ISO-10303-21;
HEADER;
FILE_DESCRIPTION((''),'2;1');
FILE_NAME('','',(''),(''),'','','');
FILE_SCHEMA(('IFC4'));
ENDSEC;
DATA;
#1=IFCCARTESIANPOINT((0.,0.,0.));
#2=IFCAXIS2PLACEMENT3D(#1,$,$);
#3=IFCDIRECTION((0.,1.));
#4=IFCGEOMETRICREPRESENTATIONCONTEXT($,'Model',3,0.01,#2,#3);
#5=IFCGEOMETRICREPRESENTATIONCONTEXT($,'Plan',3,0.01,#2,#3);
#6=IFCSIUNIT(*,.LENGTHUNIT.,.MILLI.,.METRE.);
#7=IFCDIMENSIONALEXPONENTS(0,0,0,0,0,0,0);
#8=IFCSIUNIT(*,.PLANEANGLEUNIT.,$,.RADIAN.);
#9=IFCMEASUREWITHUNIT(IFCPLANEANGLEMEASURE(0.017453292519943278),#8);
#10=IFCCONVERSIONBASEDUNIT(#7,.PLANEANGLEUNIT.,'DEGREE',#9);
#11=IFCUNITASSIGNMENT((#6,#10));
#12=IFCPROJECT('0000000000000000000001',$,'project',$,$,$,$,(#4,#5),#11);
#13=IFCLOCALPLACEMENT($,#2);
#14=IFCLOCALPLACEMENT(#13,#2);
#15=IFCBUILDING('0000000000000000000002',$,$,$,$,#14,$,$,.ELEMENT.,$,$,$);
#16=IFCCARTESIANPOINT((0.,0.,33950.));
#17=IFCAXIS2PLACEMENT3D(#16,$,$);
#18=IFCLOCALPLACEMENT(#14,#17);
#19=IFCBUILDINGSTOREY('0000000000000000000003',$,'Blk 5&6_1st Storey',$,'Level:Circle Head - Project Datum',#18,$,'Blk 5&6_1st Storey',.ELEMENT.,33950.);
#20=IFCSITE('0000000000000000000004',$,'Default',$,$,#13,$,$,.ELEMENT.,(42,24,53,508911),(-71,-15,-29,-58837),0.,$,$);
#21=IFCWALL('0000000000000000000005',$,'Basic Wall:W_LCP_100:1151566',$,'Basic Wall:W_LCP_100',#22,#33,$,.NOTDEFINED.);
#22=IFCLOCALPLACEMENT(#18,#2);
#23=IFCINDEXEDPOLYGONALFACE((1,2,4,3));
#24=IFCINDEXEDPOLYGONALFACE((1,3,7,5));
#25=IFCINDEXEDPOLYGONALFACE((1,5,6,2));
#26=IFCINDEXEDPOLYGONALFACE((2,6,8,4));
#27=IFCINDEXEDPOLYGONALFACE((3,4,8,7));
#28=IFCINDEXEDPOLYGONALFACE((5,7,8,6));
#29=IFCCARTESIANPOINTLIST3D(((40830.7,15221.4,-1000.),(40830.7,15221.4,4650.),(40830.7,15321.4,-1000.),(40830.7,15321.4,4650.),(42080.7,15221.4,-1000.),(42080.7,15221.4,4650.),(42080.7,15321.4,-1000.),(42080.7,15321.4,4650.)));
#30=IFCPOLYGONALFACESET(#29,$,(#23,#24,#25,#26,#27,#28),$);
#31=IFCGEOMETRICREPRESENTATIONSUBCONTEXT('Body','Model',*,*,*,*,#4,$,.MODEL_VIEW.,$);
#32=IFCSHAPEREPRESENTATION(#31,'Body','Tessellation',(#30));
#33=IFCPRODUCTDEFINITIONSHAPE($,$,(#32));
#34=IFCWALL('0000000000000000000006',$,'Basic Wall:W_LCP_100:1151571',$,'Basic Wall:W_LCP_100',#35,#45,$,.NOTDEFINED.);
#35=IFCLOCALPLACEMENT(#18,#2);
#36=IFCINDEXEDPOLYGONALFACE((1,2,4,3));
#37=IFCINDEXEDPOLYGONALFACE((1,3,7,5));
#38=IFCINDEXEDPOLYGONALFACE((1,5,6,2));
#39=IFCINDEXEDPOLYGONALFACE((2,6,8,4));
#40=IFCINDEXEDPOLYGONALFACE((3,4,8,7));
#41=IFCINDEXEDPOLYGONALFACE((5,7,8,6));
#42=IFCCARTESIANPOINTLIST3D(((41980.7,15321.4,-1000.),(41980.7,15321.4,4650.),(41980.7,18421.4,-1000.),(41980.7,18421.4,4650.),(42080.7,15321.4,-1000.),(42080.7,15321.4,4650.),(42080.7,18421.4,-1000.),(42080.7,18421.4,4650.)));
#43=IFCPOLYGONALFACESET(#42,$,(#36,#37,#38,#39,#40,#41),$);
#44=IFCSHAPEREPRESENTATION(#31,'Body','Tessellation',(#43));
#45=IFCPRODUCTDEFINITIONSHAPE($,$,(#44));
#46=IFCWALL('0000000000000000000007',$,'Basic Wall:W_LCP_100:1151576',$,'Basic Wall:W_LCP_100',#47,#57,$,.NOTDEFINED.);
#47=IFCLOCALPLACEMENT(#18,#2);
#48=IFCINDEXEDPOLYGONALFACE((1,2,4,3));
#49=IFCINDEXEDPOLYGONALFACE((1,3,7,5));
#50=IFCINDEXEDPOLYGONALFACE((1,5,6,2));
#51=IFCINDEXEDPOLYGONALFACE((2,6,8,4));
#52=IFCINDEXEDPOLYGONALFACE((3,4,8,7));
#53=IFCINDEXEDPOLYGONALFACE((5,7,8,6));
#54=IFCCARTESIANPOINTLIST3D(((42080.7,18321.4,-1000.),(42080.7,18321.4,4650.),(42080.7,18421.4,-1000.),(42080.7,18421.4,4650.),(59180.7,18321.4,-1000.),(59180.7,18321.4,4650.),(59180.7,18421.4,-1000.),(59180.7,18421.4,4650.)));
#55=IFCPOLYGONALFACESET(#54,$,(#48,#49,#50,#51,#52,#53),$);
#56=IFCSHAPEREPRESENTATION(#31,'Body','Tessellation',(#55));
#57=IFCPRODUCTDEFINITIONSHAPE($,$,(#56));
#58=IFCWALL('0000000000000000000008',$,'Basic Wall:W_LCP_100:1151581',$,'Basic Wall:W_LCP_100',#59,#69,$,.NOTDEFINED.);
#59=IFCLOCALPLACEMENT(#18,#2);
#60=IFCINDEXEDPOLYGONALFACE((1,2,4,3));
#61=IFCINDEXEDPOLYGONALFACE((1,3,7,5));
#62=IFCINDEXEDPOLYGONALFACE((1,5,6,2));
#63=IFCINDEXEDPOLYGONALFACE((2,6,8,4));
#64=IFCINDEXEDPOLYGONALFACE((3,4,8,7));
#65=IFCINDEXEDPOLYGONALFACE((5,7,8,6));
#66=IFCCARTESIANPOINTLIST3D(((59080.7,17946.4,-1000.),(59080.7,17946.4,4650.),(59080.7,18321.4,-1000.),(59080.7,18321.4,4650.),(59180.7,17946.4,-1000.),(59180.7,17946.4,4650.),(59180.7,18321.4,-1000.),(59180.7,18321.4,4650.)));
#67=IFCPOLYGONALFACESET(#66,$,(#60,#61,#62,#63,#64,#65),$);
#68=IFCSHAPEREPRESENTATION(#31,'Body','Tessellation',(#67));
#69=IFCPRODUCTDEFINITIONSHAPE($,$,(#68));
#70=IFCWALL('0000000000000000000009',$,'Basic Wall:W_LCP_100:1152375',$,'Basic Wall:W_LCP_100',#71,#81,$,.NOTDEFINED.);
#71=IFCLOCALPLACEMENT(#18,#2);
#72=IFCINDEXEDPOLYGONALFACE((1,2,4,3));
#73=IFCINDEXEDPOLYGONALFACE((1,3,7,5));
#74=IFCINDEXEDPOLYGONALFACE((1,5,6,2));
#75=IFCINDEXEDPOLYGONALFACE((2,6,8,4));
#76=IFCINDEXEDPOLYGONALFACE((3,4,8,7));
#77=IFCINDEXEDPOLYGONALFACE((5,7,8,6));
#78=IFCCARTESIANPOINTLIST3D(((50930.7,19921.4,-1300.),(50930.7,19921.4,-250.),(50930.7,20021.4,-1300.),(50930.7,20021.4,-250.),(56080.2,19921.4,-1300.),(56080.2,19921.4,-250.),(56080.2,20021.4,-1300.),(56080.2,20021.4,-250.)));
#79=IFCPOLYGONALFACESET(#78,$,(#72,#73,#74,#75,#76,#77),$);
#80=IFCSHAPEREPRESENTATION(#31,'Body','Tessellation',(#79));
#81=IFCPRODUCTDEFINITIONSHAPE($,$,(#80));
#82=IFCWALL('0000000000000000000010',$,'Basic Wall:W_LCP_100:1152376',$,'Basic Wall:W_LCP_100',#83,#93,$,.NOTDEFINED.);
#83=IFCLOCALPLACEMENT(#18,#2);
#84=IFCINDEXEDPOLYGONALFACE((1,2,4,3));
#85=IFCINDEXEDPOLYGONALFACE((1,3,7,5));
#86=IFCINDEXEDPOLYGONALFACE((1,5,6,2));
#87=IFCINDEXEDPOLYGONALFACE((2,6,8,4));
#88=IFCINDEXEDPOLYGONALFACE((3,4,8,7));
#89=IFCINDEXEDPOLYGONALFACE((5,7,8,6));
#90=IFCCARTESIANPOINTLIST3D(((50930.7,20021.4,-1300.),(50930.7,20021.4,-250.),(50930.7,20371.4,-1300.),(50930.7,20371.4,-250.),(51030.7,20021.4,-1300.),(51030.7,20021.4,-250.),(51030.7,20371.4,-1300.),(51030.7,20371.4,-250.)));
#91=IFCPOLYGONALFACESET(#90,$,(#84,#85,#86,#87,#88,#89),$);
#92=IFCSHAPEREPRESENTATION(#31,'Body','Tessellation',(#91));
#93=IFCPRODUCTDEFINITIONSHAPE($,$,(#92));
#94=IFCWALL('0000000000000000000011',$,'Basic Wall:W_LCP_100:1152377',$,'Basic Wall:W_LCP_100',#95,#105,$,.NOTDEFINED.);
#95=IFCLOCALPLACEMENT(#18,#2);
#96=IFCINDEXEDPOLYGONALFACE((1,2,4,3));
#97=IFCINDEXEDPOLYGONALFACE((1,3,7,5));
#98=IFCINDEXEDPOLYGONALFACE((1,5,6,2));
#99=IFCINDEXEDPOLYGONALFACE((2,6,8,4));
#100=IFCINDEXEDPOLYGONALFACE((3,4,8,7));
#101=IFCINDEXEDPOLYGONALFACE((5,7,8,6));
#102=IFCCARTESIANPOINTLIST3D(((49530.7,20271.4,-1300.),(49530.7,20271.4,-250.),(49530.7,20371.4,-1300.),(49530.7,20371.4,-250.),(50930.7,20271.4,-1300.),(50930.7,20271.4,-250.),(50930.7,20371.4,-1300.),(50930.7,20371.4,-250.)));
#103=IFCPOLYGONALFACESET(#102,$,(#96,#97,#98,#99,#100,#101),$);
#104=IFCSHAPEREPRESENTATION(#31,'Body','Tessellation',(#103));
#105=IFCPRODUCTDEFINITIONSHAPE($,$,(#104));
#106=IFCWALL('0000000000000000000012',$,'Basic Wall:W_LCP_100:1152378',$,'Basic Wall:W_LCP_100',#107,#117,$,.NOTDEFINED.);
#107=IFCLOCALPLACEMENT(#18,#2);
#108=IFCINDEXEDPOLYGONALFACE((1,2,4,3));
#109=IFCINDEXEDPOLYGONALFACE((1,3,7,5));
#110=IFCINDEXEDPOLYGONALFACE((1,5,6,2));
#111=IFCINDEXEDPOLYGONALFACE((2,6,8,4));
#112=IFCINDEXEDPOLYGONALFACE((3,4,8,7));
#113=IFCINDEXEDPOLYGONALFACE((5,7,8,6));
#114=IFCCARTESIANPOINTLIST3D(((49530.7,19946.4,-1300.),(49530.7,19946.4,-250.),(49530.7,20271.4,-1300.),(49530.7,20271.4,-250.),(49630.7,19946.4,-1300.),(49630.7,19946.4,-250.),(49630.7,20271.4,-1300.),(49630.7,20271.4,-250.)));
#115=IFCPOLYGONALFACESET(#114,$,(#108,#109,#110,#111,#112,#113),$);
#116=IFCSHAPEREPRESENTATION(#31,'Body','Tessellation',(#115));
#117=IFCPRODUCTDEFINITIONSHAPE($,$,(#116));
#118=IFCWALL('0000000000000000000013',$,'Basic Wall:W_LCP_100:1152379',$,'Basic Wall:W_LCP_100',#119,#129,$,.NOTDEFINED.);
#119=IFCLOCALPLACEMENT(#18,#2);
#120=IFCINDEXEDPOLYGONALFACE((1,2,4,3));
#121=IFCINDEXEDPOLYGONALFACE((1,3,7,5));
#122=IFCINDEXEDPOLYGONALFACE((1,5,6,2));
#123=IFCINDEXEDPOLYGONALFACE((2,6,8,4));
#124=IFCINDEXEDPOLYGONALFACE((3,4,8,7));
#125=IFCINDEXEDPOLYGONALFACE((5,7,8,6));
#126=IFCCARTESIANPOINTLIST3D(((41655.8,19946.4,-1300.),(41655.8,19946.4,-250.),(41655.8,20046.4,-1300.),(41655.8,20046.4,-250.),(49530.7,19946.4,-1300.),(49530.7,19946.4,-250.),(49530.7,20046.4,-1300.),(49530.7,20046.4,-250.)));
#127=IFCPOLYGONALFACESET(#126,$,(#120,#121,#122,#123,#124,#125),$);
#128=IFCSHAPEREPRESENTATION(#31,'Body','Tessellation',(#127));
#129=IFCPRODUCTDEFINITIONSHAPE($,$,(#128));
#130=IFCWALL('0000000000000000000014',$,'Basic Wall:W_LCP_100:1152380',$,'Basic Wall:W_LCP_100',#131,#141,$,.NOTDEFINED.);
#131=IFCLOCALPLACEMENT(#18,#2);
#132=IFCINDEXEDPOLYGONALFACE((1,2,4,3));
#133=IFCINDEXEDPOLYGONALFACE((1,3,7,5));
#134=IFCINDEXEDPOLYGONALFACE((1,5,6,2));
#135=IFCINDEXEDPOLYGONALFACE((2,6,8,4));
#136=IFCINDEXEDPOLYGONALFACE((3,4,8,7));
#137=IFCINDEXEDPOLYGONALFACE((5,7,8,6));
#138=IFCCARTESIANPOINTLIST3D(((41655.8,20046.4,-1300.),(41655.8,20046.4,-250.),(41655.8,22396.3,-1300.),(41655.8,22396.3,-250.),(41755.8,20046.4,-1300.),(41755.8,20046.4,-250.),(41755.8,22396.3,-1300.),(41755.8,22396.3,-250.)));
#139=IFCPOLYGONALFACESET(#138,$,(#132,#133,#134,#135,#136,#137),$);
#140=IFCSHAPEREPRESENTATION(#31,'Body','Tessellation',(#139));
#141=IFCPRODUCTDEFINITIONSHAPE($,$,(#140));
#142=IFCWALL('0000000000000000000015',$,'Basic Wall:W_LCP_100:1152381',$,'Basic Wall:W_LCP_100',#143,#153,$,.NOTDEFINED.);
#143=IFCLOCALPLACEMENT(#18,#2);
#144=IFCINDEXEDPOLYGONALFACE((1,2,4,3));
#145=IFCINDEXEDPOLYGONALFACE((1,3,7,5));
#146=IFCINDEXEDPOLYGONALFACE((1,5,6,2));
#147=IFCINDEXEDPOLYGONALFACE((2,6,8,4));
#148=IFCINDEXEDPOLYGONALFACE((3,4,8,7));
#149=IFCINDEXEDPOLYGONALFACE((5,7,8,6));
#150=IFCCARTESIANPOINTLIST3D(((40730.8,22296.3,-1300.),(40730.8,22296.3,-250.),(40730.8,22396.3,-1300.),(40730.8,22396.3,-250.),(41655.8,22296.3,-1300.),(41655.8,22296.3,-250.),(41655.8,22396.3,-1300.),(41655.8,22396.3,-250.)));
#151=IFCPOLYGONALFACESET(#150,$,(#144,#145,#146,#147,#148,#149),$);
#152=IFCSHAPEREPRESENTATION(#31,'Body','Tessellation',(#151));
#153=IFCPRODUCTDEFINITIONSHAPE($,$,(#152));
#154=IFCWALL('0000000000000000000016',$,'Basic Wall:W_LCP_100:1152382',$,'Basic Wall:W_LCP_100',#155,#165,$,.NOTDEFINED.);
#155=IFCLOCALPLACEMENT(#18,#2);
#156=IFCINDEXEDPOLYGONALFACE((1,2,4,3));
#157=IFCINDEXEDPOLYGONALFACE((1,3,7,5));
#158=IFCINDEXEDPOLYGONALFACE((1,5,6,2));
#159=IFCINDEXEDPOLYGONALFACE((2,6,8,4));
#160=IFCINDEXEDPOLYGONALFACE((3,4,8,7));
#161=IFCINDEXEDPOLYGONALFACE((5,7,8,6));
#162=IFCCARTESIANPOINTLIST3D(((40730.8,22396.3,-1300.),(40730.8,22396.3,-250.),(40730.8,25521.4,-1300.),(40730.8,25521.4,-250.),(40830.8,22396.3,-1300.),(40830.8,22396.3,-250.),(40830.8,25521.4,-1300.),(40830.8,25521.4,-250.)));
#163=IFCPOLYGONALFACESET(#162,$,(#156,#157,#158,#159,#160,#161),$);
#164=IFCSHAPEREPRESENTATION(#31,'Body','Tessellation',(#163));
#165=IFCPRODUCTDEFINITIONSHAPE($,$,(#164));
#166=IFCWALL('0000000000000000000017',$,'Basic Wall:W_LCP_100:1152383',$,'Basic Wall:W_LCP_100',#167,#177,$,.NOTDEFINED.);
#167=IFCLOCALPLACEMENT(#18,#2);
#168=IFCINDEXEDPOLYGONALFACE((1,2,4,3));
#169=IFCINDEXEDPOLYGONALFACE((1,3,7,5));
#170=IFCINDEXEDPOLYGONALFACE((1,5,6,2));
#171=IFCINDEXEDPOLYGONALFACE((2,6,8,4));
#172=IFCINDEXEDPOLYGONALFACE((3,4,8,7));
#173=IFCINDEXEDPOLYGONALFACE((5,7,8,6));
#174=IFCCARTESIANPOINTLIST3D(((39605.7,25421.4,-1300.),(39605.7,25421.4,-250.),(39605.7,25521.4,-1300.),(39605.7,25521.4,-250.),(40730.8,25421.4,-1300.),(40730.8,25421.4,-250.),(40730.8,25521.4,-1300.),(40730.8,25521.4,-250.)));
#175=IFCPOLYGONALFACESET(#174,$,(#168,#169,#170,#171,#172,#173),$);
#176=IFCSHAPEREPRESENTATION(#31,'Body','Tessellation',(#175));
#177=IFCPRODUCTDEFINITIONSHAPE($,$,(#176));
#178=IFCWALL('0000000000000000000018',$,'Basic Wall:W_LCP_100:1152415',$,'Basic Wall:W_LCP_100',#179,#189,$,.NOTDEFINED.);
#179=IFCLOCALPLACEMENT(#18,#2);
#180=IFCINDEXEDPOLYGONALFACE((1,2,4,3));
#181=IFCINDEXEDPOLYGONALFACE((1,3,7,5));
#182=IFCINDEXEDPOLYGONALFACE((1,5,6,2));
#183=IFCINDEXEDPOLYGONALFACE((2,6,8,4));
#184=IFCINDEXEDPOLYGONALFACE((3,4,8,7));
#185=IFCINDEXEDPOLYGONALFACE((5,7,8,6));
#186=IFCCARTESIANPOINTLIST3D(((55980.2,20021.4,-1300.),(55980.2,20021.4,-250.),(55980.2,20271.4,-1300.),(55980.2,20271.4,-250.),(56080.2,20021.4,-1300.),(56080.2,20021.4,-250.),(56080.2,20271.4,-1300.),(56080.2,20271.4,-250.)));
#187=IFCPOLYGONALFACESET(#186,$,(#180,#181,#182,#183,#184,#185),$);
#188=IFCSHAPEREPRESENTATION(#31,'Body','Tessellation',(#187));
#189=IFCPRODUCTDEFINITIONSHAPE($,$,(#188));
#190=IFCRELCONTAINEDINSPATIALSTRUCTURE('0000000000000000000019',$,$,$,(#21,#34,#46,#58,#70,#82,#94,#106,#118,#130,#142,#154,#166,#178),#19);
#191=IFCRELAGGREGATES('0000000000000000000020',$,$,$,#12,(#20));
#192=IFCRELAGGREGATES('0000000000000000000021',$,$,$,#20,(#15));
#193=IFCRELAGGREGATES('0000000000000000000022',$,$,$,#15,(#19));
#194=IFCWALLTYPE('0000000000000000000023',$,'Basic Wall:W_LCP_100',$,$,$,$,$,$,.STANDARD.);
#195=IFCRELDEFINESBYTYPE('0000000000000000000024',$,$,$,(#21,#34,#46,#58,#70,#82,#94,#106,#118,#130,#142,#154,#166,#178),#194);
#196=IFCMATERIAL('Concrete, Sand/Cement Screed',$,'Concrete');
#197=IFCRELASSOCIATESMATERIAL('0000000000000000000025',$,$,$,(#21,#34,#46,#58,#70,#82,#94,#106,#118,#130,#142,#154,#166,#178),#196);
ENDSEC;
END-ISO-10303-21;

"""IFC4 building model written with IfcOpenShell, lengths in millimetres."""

from ifc_helpers import new_model, entity, si_unit, converted_unit, direction, frame, origin, place, context, subcontext, project, spatial, indexed_curve, outline, extrude, material, type_object, element, save


model = new_model("IFC4")

# Units and contexts
model_context = context("Model", 3, precision=0.01, world=origin(), true_north=direction((0.0, 1.0)))
plan_context = context("Plan", 3, precision=0.01, world=origin(), true_north=direction((0.0, 1.0)))
body_context = subcontext(model_context, "Body", "Model", "MODEL_VIEW")
ifc_project = project(units=[si_unit("LENGTHUNIT", "METRE", prefix="MILLI"), converted_unit("PLANEANGLEUNIT", "DEGREE", entity("IfcPlaneAngleMeasure", 0.017453292519943278), si_unit("PLANEANGLEUNIT", "RADIAN"), dimensions=[0, 0, 0, 0, 0, 0, 0])], contexts=[model_context, plan_context])

# Site, building, storey
site_placement = place(None, origin())
site = spatial("IfcSite", under=ifc_project, at=site_placement, Name="Default", CompositionType="ELEMENT", RefLatitude=(42, 24, 53, 508911), RefLongitude=(-71, -15, -29, -58837), RefElevation=0.0)
building_placement = place(site_placement, origin())
building = spatial("IfcBuilding", under=site, at=building_placement, CompositionType="ELEMENT")
storey_placement = place(building_placement, frame((0.0, 0.0, 33950.0)))
storey = spatial("IfcBuildingStorey", under=building, at=storey_placement, Name="Blk 5&6_1st Storey", ObjectType="Level:Circle Head - Project Datum", LongName="Blk 5&6_1st Storey", CompositionType="ELEMENT", Elevation=33950.0)

# Walls
ifc_material = material(Name="Concrete, Sand/Cement Screed", Category="Concrete")
wall_type = type_object("IfcWallType", Name="Basic Wall:W_LCP_100", PredefinedType="STANDARD")
wall_1_placement = place(storey_placement, frame((40830.7, 15271.4, -1000.0)))
element("IfcWall", 1, at=wall_1_placement, inside=storey, type_object=wall_type, material=ifc_material, Name="Basic Wall:W_LCP_100:1151566", ObjectType="Basic Wall:W_LCP_100", PredefinedType="NOTDEFINED", context=body_context, shape_type="SweptSolid", body=[
    extrude(outline(indexed_curve([(1250.0, 50.0), (0.0, 50.0), (0.0, -50.0), (1250.0, -50.0), (1250.0, 50.0)], self_intersect=False)), origin(), (0.0, 0.0, 1.0), 5650.0),
])
wall_2_placement = place(storey_placement, frame((42030.7, 15321.4, -1000.0), z_axis=(0.0, 0.0, 1.0), x_axis=(0.0, 1.0, 0.0)))
element("IfcWall", 2, at=wall_2_placement, inside=storey, type_object=wall_type, material=ifc_material, Name="Basic Wall:W_LCP_100:1151571", ObjectType="Basic Wall:W_LCP_100", PredefinedType="NOTDEFINED", context=body_context, shape_type="SweptSolid", body=[
    extrude(outline(indexed_curve([(3100.0, 50.0), (0.0, 50.0), (0.0, -50.0), (3100.0, -50.0), (3100.0, 50.0)], self_intersect=False)), origin(), (0.0, 0.0, 1.0), 5650.0),
])
wall_3_placement = place(storey_placement, frame((42080.7, 18371.4, -1000.0)))
element("IfcWall", 3, at=wall_3_placement, inside=storey, type_object=wall_type, material=ifc_material, Name="Basic Wall:W_LCP_100:1151576", ObjectType="Basic Wall:W_LCP_100", PredefinedType="NOTDEFINED", context=body_context, shape_type="SweptSolid", body=[
    extrude(outline(indexed_curve([(17100.0, 50.0), (0.0, 50.0), (0.0, -50.0), (17100.0, -50.0), (17100.0, 50.0)], self_intersect=False)), origin(), (0.0, 0.0, 1.0), 5650.0),
])
wall_4_placement = place(storey_placement, frame((59130.7, 18321.4, -1000.0), z_axis=(0.0, 0.0, 1.0), x_axis=(0.0, -1.0, 0.0)))
element("IfcWall", 4, at=wall_4_placement, inside=storey, type_object=wall_type, material=ifc_material, Name="Basic Wall:W_LCP_100:1151581", ObjectType="Basic Wall:W_LCP_100", PredefinedType="NOTDEFINED", context=body_context, shape_type="SweptSolid", body=[
    extrude(outline(indexed_curve([(375.0, 50.0), (0.0, 50.0), (0.0, -50.0), (375.0, -50.0), (375.0, 50.0)], self_intersect=False)), origin(), (0.0, 0.0, 1.0), 5650.0),
])
wall_5_placement = place(storey_placement, frame((56080.2, 19971.4, -1300.0), z_axis=(0.0, 0.0, 1.0), x_axis=(-1.0, 0.0, 0.0)))
element("IfcWall", 5, at=wall_5_placement, inside=storey, type_object=wall_type, material=ifc_material, Name="Basic Wall:W_LCP_100:1152375", ObjectType="Basic Wall:W_LCP_100", PredefinedType="NOTDEFINED", context=body_context, shape_type="SweptSolid", body=[
    extrude(outline(indexed_curve([(5149.5, 50.0), (0.0, 50.0), (0.0, -50.0), (5149.5, -50.0), (5149.5, 50.0)], self_intersect=False)), origin(), (0.0, 0.0, 1.0), 1050.0),
])
wall_6_placement = place(storey_placement, frame((50980.7, 20021.4, -1300.0), z_axis=(0.0, 0.0, 1.0), x_axis=(0.0, 1.0, 0.0)))
element("IfcWall", 6, at=wall_6_placement, inside=storey, type_object=wall_type, material=ifc_material, Name="Basic Wall:W_LCP_100:1152376", ObjectType="Basic Wall:W_LCP_100", PredefinedType="NOTDEFINED", context=body_context, shape_type="SweptSolid", body=[
    extrude(outline(indexed_curve([(350.0, 50.0), (0.0, 50.0), (0.0, -50.0), (350.0, -50.0), (350.0, 50.0)], self_intersect=False)), origin(), (0.0, 0.0, 1.0), 1050.0),
])
wall_7_placement = place(storey_placement, frame((50930.7, 20321.4, -1300.0), z_axis=(0.0, 0.0, 1.0), x_axis=(-1.0, 0.0, 0.0)))
element("IfcWall", 7, at=wall_7_placement, inside=storey, type_object=wall_type, material=ifc_material, Name="Basic Wall:W_LCP_100:1152377", ObjectType="Basic Wall:W_LCP_100", PredefinedType="NOTDEFINED", context=body_context, shape_type="SweptSolid", body=[
    extrude(outline(indexed_curve([(1400.0, 50.0), (0.0, 50.0), (0.0, -50.0), (1400.0, -50.0), (1400.0, 50.0)], self_intersect=False)), origin(), (0.0, 0.0, 1.0), 1050.0),
])
wall_8_placement = place(storey_placement, frame((49580.7, 20271.4, -1300.0), z_axis=(0.0, 0.0, 1.0), x_axis=(0.0, -1.0, 0.0)))
element("IfcWall", 8, at=wall_8_placement, inside=storey, type_object=wall_type, material=ifc_material, Name="Basic Wall:W_LCP_100:1152378", ObjectType="Basic Wall:W_LCP_100", PredefinedType="NOTDEFINED", context=body_context, shape_type="SweptSolid", body=[
    extrude(outline(indexed_curve([(325.0, 50.0), (0.0, 50.0), (0.0, -50.0), (325.0, -50.0), (325.0, 50.0)], self_intersect=False)), origin(), (0.0, 0.0, 1.0), 1050.0),
])
wall_9_placement = place(storey_placement, frame((49530.7, 19996.4, -1300.0), z_axis=(0.0, 0.0, 1.0), x_axis=(-1.0, 0.0, 0.0)))
element("IfcWall", 9, at=wall_9_placement, inside=storey, type_object=wall_type, material=ifc_material, Name="Basic Wall:W_LCP_100:1152379", ObjectType="Basic Wall:W_LCP_100", PredefinedType="NOTDEFINED", context=body_context, shape_type="SweptSolid", body=[
    extrude(outline(indexed_curve([(7874.8, 50.0), (0.0, 50.0), (0.0, -50.0), (7874.8, -50.0), (7874.8, 50.0)], self_intersect=False)), origin(), (0.0, 0.0, 1.0), 1050.0),
])
wall_10_placement = place(storey_placement, frame((41705.8, 20046.4, -1300.0), z_axis=(0.0, 0.0, 1.0), x_axis=(0.0, 1.0, 0.0)))
element("IfcWall", 10, at=wall_10_placement, inside=storey, type_object=wall_type, material=ifc_material, Name="Basic Wall:W_LCP_100:1152380", ObjectType="Basic Wall:W_LCP_100", PredefinedType="NOTDEFINED", context=body_context, shape_type="SweptSolid", body=[
    extrude(outline(indexed_curve([(2350.0, 50.0), (0.0, 50.0), (0.0, -50.0), (2350.0, -50.0), (2350.0, 50.0)], self_intersect=False)), origin(), (0.0, 0.0, 1.0), 1050.0),
])
wall_11_placement = place(storey_placement, frame((41655.8, 22346.3, -1300.0), z_axis=(0.0, 0.0, 1.0), x_axis=(-1.0, 0.0, 0.0)))
element("IfcWall", 11, at=wall_11_placement, inside=storey, type_object=wall_type, material=ifc_material, Name="Basic Wall:W_LCP_100:1152381", ObjectType="Basic Wall:W_LCP_100", PredefinedType="NOTDEFINED", context=body_context, shape_type="SweptSolid", body=[
    extrude(outline(indexed_curve([(925.0, 50.0), (0.0, 50.0), (0.0, -50.0), (925.0, -50.0), (925.0, 50.0)], self_intersect=False)), origin(), (0.0, 0.0, 1.0), 1050.0),
])
wall_12_placement = place(storey_placement, frame((40780.8, 22396.3, -1300.0), z_axis=(0.0, 0.0, 1.0), x_axis=(0.0, 1.0, 0.0)))
element("IfcWall", 12, at=wall_12_placement, inside=storey, type_object=wall_type, material=ifc_material, Name="Basic Wall:W_LCP_100:1152382", ObjectType="Basic Wall:W_LCP_100", PredefinedType="NOTDEFINED", context=body_context, shape_type="SweptSolid", body=[
    extrude(outline(indexed_curve([(3125.0, 50.0), (0.0, 50.0), (0.0, -50.0), (3125.0, -50.0), (3125.0, 50.0)], self_intersect=False)), origin(), (0.0, 0.0, 1.0), 1050.0),
])
wall_13_placement = place(storey_placement, frame((40730.8, 25471.4, -1300.0), z_axis=(0.0, 0.0, 1.0), x_axis=(-1.0, 0.0, 0.0)))
element("IfcWall", 13, at=wall_13_placement, inside=storey, type_object=wall_type, material=ifc_material, Name="Basic Wall:W_LCP_100:1152383", ObjectType="Basic Wall:W_LCP_100", PredefinedType="NOTDEFINED", context=body_context, shape_type="SweptSolid", body=[
    extrude(outline(indexed_curve([(1125.2, 50.0), (0.0, 50.0), (0.0, -50.0), (1125.2, -50.0), (1125.2, 50.0)], self_intersect=False)), origin(), (0.0, 0.0, 1.0), 1050.0),
])
wall_14_placement = place(storey_placement, frame((56030.2, 20271.4, -1300.0), z_axis=(0.0, 0.0, 1.0), x_axis=(0.0, -1.0, 0.0)))
element("IfcWall", 14, at=wall_14_placement, inside=storey, type_object=wall_type, material=ifc_material, Name="Basic Wall:W_LCP_100:1152415", ObjectType="Basic Wall:W_LCP_100", PredefinedType="NOTDEFINED", context=body_context, shape_type="SweptSolid", body=[
    extrude(outline(indexed_curve([(250.0, 50.0), (0.0, 50.0), (0.0, -50.0), (250.0, -50.0), (250.0, 50.0)], self_intersect=False)), origin(), (0.0, 0.0, 1.0), 1050.0),
])

save(model, "model.ifc")
